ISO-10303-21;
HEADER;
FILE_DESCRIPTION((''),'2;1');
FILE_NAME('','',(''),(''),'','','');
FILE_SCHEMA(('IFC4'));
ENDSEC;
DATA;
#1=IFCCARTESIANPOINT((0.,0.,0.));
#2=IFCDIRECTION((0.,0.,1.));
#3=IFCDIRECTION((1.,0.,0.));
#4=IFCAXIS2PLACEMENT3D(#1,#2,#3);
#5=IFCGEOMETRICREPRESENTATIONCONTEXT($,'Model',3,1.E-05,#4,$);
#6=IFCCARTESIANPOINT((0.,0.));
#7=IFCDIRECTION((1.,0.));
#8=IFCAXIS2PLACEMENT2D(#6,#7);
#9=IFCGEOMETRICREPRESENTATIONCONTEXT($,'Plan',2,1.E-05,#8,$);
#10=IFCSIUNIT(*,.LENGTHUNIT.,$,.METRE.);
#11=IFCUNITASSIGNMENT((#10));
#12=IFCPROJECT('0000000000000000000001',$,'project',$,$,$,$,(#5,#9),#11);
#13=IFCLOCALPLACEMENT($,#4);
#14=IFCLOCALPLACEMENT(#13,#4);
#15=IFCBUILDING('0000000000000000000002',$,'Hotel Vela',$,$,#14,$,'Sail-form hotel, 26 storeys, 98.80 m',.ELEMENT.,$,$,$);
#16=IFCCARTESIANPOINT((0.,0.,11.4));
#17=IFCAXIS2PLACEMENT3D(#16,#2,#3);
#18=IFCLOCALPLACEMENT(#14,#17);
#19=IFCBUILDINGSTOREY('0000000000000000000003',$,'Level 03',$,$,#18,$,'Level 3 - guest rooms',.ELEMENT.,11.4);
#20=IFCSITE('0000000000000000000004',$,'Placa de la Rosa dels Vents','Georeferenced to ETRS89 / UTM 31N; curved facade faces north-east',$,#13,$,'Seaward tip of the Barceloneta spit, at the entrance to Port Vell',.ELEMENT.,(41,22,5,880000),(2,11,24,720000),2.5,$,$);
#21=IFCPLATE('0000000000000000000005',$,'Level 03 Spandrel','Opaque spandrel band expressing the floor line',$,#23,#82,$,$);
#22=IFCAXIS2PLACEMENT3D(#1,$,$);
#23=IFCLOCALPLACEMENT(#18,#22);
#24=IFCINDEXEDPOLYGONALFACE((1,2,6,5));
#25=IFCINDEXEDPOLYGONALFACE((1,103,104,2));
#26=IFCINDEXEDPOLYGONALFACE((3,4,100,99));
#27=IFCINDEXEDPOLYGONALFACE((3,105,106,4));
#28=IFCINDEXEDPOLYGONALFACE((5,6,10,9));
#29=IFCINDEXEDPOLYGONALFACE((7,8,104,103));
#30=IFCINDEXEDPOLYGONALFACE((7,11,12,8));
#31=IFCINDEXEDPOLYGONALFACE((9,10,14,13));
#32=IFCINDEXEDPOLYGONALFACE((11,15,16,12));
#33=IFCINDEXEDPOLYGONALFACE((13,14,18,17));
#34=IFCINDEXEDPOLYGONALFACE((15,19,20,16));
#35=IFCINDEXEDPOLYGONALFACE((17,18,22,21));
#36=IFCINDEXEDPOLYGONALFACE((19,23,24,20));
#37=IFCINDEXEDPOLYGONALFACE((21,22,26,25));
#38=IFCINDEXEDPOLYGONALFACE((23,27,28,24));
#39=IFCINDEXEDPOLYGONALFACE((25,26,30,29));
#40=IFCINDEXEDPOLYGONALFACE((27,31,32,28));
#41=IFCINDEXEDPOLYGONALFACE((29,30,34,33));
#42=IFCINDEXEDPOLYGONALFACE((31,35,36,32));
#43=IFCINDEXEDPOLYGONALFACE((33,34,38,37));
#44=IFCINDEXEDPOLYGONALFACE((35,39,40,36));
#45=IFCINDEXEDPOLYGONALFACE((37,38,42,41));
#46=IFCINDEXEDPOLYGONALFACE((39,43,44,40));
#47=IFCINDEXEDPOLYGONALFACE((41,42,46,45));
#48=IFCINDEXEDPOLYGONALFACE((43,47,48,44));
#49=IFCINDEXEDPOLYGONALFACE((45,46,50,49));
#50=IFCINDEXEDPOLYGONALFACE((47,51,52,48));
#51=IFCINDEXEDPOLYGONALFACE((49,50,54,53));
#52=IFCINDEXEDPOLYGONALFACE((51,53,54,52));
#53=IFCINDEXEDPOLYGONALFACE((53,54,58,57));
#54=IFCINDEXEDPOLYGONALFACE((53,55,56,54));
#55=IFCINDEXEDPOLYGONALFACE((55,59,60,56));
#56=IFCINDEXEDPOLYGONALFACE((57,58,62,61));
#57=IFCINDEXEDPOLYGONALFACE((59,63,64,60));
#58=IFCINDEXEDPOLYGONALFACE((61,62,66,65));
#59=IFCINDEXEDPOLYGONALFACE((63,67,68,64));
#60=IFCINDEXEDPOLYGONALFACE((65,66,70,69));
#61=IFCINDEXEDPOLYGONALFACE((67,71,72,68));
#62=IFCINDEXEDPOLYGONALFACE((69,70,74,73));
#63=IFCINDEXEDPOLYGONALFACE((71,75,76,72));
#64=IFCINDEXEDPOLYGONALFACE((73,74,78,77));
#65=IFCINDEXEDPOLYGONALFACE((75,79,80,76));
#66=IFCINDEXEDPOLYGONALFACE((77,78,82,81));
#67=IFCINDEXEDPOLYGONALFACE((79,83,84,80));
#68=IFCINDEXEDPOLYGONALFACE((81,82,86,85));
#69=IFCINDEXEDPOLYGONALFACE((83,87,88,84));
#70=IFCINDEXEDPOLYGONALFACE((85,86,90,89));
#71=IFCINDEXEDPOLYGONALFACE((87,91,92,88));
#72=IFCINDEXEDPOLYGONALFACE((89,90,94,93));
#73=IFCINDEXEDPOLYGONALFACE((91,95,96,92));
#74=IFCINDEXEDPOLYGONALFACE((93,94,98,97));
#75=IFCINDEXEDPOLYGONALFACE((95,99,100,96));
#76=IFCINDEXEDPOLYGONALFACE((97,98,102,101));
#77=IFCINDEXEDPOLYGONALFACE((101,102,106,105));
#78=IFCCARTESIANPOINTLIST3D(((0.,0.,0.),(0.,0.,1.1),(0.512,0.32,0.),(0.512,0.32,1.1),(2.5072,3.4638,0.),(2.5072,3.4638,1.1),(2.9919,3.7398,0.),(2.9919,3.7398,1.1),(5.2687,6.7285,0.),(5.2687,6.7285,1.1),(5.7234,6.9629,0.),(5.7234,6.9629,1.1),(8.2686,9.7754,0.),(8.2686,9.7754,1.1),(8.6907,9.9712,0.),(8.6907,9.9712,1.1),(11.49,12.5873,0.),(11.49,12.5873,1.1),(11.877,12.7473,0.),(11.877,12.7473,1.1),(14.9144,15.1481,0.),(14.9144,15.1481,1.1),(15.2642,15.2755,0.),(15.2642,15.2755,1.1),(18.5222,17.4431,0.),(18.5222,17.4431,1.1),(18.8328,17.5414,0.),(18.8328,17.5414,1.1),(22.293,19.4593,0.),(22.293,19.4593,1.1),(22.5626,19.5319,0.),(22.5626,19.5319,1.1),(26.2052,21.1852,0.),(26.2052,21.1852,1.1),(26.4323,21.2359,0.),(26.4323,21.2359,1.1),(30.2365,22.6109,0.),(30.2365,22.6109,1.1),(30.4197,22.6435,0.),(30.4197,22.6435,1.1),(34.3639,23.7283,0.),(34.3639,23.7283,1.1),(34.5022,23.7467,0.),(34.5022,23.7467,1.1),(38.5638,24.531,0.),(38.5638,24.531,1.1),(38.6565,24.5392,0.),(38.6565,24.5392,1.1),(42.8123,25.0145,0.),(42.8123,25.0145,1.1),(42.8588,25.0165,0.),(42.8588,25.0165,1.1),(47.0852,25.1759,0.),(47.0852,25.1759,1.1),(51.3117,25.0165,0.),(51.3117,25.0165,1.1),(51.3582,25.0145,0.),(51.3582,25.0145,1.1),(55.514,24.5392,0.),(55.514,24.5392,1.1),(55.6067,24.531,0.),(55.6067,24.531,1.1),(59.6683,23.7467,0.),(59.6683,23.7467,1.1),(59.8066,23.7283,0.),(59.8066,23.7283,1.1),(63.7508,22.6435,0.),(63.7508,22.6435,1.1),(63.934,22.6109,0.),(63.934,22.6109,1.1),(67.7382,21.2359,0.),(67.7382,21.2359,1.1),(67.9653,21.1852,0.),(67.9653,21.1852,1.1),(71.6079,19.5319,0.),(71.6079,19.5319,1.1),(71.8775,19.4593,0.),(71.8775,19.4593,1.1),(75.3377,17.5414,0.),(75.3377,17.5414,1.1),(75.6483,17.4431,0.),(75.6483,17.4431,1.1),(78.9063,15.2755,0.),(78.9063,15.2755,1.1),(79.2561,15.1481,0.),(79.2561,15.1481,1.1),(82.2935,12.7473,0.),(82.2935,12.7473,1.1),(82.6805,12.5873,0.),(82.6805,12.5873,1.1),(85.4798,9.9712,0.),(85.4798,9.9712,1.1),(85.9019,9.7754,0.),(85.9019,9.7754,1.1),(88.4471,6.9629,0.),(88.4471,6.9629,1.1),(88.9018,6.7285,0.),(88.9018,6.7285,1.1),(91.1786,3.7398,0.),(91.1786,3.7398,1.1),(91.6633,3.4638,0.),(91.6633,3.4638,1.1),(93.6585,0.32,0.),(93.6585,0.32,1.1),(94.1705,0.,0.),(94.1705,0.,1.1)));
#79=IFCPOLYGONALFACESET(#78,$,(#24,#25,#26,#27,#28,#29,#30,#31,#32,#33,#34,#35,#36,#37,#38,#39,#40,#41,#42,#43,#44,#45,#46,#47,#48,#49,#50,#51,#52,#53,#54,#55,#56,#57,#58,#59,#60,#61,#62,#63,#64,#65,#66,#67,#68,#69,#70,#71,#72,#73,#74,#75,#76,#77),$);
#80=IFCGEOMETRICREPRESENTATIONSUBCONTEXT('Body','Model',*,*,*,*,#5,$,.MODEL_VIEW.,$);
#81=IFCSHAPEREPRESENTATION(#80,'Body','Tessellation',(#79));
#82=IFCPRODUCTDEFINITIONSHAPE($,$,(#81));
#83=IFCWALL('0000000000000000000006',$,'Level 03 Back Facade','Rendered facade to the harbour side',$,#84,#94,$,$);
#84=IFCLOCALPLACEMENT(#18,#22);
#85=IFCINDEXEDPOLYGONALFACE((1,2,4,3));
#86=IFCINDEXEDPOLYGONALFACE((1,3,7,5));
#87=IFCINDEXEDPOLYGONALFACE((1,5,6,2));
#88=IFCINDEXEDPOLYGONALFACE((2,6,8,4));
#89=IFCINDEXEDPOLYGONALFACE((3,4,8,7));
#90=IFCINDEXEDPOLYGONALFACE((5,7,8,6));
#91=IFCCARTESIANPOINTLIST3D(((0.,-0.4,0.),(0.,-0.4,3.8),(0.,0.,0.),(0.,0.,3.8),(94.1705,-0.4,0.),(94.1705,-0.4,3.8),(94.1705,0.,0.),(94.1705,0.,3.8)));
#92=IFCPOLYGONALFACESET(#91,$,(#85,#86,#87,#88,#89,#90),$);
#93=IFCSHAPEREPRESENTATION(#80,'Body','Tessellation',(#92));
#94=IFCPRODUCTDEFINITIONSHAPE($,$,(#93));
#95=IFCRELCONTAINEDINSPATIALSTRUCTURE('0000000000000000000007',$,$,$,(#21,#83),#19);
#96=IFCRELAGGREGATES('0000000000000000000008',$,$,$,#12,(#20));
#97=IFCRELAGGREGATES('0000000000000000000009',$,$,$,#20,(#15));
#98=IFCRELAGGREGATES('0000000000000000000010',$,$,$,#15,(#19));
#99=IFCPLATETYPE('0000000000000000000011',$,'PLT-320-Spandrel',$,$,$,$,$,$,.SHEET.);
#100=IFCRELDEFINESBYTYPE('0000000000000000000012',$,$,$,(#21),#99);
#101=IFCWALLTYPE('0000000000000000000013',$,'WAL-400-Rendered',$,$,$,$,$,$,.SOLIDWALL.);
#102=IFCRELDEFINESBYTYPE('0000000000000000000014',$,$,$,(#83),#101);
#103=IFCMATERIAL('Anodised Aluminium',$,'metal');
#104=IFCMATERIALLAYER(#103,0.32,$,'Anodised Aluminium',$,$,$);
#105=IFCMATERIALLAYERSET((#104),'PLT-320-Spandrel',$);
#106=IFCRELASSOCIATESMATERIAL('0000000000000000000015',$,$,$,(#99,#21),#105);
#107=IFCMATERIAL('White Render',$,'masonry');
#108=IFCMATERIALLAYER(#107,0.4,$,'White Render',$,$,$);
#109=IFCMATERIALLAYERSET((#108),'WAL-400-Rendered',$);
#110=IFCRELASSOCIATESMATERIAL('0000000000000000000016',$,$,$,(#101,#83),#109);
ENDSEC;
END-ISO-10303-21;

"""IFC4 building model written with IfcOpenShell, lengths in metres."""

from ifc_helpers import new_model, si_unit, frame, origin_with_axes, origin_2d_with_axis, place, context, subcontext, project, spatial, line, indexed_curve, outline, extrude, material, layer, layer_set, layer_usage, type_object, element, save


model = new_model("IFC4")

# Units and contexts
model_context = context("Model", 3, precision=1e-05, world=origin_with_axes())
plan_context = context("Plan", 2, precision=1e-05, world=origin_2d_with_axis())
body_context = subcontext(model_context, "Body", "Model", "MODEL_VIEW")
ifc_project = project(units=[si_unit("LENGTHUNIT", "METRE")], contexts=[model_context, plan_context])

# Site, building, storey
site_placement = place(None, origin_with_axes())
site = spatial("IfcSite", under=ifc_project, at=site_placement, Name="Placa de la Rosa dels Vents", Description="Georeferenced to ETRS89 / UTM 31N; curved facade faces north-east", LongName="Seaward tip of the Barceloneta spit, at the entrance to Port Vell", CompositionType="ELEMENT", RefLatitude=(41, 22, 5, 880000), RefLongitude=(2, 11, 24, 720000), RefElevation=2.5)
building_placement = place(site_placement, origin_with_axes())
building = spatial("IfcBuilding", under=site, at=building_placement, Name="Hotel Vela", LongName="Sail-form hotel, 26 storeys, 98.80 m", CompositionType="ELEMENT")
storey_placement = place(building_placement, frame((0.0, 0.0, 11.4), z_axis=(0.0, 0.0, 1.0), x_axis=(1.0, 0.0, 0.0)))
storey = spatial("IfcBuildingStorey", under=building, at=storey_placement, Name="Level 03", LongName="Level 3 - guest rooms", CompositionType="ELEMENT", Elevation=11.4)

# Plate
ifc_material_1 = material(Name="Anodised Aluminium", Category="metal")
ifc_layer_1 = layer(ifc_material_1, 0.32, Name="Anodised Aluminium")
ifc_layer_set_1 = layer_set([ifc_layer_1], Name="PLT-320-Spandrel")
ifc_layer_usage_1 = layer_usage(ifc_layer_set_1, "AXIS2", "POSITIVE", 0.0)
plate_type_1 = type_object("IfcPlateType", Name="PLT-320-Spandrel", PredefinedType="SHEET", material=ifc_layer_set_1)
plate_1_placement = place(storey_placement, origin_with_axes())
element("IfcPlate", 1, at=plate_1_placement, inside=storey, type_object=plate_type_1, material=ifc_layer_usage_1, Name="Level 03 Spandrel", Description="Opaque spandrel band expressing the floor line", context=body_context, shape_type="SweptSolid", body=[
    extrude(outline(indexed_curve([(94.1705, 0.0), (91.6633, 3.4638), (88.9018, 6.7285), (85.9019, 9.7754), (82.6805, 12.5873), (79.2561, 15.1481), (75.6483, 17.4431), (71.8775, 19.4593), (67.9653, 21.1852), (63.934, 22.6109), (59.8066, 23.7283), (55.6067, 24.531), (51.3582, 25.0145), (47.0852, 25.1759), (42.8123, 25.0145), (38.5638, 24.531), (34.3639, 23.7283), (30.2365, 22.6109), (26.2052, 21.1852), (22.293, 19.4593), (18.5222, 17.4431), (14.9144, 15.1481), (11.49, 12.5873), (8.2686, 9.7754), (5.2687, 6.7285), (2.5072, 3.4638), (0.0, 0.0), (93.6585, 0.32), (2.9919, 3.7398), (5.7234, 6.9629), (8.6907, 9.9712), (11.877, 12.7473), (15.2642, 15.2755), (18.8328, 17.5414), (22.5626, 19.5319), (26.4323, 21.2359), (30.4197, 22.6435), (34.5022, 23.7467), (38.6565, 24.5392), (42.8588, 25.0165), (47.0852, 25.1759), (51.3117, 25.0165), (55.514, 24.5392), (59.6683, 23.7467), (63.7508, 22.6435), (67.7382, 21.2359), (71.6079, 19.5319), (75.3377, 17.5414), (78.9063, 15.2755), (82.2935, 12.7473), (85.4798, 9.9712), (88.4471, 6.9629), (91.1786, 3.7398), (0.512, 0.32)], segments=[line(1, 2, 3, 4, 5, 6, 7, 8, 9, 10, 11, 12, 13, 14, 15, 16, 17, 18, 19, 20, 21, 22, 23, 24, 25, 26, 27, 28, 29, 30, 31, 32, 33, 34, 35, 36, 37, 38, 39, 40, 41, 42, 43, 44, 45, 46, 47, 48, 49, 50, 51, 52, 53, 54, 1)])), origin_with_axes(), (0.0, 0.0, 1.0), 1.1),
])

# Wall
ifc_material_2 = material(Name="White Render", Category="masonry")
ifc_layer_2 = layer(ifc_material_2, 0.4, Name="White Render")
ifc_layer_set_2 = layer_set([ifc_layer_2], Name="WAL-400-Rendered")
ifc_layer_usage_2 = layer_usage(ifc_layer_set_2, "AXIS2", "POSITIVE", 0.0)
wall_type = type_object("IfcWallType", Name="WAL-400-Rendered", PredefinedType="SOLIDWALL", material=ifc_layer_set_2)
wall_placement = place(storey_placement, frame((0.0, -0.4, 0.0), z_axis=(0.0, 0.0, 1.0), x_axis=(1.0, 0.0, 0.0)))
element("IfcWall", 2, at=wall_placement, inside=storey, type_object=wall_type, material=ifc_layer_usage_2, Name="Level 03 Back Facade", Description="Rendered facade to the harbour side", context=body_context, shape_type="SweptSolid", body=[
    extrude(outline(indexed_curve([(0.0, 0.0), (94.1705, 0.0), (94.1705, 0.4), (0.0, 0.4)], segments=[line(1, 2, 3, 4, 1)])), origin_with_axes(), (0.0, 0.0, 1.0), 3.8),
])

save(model, "model.ifc")
